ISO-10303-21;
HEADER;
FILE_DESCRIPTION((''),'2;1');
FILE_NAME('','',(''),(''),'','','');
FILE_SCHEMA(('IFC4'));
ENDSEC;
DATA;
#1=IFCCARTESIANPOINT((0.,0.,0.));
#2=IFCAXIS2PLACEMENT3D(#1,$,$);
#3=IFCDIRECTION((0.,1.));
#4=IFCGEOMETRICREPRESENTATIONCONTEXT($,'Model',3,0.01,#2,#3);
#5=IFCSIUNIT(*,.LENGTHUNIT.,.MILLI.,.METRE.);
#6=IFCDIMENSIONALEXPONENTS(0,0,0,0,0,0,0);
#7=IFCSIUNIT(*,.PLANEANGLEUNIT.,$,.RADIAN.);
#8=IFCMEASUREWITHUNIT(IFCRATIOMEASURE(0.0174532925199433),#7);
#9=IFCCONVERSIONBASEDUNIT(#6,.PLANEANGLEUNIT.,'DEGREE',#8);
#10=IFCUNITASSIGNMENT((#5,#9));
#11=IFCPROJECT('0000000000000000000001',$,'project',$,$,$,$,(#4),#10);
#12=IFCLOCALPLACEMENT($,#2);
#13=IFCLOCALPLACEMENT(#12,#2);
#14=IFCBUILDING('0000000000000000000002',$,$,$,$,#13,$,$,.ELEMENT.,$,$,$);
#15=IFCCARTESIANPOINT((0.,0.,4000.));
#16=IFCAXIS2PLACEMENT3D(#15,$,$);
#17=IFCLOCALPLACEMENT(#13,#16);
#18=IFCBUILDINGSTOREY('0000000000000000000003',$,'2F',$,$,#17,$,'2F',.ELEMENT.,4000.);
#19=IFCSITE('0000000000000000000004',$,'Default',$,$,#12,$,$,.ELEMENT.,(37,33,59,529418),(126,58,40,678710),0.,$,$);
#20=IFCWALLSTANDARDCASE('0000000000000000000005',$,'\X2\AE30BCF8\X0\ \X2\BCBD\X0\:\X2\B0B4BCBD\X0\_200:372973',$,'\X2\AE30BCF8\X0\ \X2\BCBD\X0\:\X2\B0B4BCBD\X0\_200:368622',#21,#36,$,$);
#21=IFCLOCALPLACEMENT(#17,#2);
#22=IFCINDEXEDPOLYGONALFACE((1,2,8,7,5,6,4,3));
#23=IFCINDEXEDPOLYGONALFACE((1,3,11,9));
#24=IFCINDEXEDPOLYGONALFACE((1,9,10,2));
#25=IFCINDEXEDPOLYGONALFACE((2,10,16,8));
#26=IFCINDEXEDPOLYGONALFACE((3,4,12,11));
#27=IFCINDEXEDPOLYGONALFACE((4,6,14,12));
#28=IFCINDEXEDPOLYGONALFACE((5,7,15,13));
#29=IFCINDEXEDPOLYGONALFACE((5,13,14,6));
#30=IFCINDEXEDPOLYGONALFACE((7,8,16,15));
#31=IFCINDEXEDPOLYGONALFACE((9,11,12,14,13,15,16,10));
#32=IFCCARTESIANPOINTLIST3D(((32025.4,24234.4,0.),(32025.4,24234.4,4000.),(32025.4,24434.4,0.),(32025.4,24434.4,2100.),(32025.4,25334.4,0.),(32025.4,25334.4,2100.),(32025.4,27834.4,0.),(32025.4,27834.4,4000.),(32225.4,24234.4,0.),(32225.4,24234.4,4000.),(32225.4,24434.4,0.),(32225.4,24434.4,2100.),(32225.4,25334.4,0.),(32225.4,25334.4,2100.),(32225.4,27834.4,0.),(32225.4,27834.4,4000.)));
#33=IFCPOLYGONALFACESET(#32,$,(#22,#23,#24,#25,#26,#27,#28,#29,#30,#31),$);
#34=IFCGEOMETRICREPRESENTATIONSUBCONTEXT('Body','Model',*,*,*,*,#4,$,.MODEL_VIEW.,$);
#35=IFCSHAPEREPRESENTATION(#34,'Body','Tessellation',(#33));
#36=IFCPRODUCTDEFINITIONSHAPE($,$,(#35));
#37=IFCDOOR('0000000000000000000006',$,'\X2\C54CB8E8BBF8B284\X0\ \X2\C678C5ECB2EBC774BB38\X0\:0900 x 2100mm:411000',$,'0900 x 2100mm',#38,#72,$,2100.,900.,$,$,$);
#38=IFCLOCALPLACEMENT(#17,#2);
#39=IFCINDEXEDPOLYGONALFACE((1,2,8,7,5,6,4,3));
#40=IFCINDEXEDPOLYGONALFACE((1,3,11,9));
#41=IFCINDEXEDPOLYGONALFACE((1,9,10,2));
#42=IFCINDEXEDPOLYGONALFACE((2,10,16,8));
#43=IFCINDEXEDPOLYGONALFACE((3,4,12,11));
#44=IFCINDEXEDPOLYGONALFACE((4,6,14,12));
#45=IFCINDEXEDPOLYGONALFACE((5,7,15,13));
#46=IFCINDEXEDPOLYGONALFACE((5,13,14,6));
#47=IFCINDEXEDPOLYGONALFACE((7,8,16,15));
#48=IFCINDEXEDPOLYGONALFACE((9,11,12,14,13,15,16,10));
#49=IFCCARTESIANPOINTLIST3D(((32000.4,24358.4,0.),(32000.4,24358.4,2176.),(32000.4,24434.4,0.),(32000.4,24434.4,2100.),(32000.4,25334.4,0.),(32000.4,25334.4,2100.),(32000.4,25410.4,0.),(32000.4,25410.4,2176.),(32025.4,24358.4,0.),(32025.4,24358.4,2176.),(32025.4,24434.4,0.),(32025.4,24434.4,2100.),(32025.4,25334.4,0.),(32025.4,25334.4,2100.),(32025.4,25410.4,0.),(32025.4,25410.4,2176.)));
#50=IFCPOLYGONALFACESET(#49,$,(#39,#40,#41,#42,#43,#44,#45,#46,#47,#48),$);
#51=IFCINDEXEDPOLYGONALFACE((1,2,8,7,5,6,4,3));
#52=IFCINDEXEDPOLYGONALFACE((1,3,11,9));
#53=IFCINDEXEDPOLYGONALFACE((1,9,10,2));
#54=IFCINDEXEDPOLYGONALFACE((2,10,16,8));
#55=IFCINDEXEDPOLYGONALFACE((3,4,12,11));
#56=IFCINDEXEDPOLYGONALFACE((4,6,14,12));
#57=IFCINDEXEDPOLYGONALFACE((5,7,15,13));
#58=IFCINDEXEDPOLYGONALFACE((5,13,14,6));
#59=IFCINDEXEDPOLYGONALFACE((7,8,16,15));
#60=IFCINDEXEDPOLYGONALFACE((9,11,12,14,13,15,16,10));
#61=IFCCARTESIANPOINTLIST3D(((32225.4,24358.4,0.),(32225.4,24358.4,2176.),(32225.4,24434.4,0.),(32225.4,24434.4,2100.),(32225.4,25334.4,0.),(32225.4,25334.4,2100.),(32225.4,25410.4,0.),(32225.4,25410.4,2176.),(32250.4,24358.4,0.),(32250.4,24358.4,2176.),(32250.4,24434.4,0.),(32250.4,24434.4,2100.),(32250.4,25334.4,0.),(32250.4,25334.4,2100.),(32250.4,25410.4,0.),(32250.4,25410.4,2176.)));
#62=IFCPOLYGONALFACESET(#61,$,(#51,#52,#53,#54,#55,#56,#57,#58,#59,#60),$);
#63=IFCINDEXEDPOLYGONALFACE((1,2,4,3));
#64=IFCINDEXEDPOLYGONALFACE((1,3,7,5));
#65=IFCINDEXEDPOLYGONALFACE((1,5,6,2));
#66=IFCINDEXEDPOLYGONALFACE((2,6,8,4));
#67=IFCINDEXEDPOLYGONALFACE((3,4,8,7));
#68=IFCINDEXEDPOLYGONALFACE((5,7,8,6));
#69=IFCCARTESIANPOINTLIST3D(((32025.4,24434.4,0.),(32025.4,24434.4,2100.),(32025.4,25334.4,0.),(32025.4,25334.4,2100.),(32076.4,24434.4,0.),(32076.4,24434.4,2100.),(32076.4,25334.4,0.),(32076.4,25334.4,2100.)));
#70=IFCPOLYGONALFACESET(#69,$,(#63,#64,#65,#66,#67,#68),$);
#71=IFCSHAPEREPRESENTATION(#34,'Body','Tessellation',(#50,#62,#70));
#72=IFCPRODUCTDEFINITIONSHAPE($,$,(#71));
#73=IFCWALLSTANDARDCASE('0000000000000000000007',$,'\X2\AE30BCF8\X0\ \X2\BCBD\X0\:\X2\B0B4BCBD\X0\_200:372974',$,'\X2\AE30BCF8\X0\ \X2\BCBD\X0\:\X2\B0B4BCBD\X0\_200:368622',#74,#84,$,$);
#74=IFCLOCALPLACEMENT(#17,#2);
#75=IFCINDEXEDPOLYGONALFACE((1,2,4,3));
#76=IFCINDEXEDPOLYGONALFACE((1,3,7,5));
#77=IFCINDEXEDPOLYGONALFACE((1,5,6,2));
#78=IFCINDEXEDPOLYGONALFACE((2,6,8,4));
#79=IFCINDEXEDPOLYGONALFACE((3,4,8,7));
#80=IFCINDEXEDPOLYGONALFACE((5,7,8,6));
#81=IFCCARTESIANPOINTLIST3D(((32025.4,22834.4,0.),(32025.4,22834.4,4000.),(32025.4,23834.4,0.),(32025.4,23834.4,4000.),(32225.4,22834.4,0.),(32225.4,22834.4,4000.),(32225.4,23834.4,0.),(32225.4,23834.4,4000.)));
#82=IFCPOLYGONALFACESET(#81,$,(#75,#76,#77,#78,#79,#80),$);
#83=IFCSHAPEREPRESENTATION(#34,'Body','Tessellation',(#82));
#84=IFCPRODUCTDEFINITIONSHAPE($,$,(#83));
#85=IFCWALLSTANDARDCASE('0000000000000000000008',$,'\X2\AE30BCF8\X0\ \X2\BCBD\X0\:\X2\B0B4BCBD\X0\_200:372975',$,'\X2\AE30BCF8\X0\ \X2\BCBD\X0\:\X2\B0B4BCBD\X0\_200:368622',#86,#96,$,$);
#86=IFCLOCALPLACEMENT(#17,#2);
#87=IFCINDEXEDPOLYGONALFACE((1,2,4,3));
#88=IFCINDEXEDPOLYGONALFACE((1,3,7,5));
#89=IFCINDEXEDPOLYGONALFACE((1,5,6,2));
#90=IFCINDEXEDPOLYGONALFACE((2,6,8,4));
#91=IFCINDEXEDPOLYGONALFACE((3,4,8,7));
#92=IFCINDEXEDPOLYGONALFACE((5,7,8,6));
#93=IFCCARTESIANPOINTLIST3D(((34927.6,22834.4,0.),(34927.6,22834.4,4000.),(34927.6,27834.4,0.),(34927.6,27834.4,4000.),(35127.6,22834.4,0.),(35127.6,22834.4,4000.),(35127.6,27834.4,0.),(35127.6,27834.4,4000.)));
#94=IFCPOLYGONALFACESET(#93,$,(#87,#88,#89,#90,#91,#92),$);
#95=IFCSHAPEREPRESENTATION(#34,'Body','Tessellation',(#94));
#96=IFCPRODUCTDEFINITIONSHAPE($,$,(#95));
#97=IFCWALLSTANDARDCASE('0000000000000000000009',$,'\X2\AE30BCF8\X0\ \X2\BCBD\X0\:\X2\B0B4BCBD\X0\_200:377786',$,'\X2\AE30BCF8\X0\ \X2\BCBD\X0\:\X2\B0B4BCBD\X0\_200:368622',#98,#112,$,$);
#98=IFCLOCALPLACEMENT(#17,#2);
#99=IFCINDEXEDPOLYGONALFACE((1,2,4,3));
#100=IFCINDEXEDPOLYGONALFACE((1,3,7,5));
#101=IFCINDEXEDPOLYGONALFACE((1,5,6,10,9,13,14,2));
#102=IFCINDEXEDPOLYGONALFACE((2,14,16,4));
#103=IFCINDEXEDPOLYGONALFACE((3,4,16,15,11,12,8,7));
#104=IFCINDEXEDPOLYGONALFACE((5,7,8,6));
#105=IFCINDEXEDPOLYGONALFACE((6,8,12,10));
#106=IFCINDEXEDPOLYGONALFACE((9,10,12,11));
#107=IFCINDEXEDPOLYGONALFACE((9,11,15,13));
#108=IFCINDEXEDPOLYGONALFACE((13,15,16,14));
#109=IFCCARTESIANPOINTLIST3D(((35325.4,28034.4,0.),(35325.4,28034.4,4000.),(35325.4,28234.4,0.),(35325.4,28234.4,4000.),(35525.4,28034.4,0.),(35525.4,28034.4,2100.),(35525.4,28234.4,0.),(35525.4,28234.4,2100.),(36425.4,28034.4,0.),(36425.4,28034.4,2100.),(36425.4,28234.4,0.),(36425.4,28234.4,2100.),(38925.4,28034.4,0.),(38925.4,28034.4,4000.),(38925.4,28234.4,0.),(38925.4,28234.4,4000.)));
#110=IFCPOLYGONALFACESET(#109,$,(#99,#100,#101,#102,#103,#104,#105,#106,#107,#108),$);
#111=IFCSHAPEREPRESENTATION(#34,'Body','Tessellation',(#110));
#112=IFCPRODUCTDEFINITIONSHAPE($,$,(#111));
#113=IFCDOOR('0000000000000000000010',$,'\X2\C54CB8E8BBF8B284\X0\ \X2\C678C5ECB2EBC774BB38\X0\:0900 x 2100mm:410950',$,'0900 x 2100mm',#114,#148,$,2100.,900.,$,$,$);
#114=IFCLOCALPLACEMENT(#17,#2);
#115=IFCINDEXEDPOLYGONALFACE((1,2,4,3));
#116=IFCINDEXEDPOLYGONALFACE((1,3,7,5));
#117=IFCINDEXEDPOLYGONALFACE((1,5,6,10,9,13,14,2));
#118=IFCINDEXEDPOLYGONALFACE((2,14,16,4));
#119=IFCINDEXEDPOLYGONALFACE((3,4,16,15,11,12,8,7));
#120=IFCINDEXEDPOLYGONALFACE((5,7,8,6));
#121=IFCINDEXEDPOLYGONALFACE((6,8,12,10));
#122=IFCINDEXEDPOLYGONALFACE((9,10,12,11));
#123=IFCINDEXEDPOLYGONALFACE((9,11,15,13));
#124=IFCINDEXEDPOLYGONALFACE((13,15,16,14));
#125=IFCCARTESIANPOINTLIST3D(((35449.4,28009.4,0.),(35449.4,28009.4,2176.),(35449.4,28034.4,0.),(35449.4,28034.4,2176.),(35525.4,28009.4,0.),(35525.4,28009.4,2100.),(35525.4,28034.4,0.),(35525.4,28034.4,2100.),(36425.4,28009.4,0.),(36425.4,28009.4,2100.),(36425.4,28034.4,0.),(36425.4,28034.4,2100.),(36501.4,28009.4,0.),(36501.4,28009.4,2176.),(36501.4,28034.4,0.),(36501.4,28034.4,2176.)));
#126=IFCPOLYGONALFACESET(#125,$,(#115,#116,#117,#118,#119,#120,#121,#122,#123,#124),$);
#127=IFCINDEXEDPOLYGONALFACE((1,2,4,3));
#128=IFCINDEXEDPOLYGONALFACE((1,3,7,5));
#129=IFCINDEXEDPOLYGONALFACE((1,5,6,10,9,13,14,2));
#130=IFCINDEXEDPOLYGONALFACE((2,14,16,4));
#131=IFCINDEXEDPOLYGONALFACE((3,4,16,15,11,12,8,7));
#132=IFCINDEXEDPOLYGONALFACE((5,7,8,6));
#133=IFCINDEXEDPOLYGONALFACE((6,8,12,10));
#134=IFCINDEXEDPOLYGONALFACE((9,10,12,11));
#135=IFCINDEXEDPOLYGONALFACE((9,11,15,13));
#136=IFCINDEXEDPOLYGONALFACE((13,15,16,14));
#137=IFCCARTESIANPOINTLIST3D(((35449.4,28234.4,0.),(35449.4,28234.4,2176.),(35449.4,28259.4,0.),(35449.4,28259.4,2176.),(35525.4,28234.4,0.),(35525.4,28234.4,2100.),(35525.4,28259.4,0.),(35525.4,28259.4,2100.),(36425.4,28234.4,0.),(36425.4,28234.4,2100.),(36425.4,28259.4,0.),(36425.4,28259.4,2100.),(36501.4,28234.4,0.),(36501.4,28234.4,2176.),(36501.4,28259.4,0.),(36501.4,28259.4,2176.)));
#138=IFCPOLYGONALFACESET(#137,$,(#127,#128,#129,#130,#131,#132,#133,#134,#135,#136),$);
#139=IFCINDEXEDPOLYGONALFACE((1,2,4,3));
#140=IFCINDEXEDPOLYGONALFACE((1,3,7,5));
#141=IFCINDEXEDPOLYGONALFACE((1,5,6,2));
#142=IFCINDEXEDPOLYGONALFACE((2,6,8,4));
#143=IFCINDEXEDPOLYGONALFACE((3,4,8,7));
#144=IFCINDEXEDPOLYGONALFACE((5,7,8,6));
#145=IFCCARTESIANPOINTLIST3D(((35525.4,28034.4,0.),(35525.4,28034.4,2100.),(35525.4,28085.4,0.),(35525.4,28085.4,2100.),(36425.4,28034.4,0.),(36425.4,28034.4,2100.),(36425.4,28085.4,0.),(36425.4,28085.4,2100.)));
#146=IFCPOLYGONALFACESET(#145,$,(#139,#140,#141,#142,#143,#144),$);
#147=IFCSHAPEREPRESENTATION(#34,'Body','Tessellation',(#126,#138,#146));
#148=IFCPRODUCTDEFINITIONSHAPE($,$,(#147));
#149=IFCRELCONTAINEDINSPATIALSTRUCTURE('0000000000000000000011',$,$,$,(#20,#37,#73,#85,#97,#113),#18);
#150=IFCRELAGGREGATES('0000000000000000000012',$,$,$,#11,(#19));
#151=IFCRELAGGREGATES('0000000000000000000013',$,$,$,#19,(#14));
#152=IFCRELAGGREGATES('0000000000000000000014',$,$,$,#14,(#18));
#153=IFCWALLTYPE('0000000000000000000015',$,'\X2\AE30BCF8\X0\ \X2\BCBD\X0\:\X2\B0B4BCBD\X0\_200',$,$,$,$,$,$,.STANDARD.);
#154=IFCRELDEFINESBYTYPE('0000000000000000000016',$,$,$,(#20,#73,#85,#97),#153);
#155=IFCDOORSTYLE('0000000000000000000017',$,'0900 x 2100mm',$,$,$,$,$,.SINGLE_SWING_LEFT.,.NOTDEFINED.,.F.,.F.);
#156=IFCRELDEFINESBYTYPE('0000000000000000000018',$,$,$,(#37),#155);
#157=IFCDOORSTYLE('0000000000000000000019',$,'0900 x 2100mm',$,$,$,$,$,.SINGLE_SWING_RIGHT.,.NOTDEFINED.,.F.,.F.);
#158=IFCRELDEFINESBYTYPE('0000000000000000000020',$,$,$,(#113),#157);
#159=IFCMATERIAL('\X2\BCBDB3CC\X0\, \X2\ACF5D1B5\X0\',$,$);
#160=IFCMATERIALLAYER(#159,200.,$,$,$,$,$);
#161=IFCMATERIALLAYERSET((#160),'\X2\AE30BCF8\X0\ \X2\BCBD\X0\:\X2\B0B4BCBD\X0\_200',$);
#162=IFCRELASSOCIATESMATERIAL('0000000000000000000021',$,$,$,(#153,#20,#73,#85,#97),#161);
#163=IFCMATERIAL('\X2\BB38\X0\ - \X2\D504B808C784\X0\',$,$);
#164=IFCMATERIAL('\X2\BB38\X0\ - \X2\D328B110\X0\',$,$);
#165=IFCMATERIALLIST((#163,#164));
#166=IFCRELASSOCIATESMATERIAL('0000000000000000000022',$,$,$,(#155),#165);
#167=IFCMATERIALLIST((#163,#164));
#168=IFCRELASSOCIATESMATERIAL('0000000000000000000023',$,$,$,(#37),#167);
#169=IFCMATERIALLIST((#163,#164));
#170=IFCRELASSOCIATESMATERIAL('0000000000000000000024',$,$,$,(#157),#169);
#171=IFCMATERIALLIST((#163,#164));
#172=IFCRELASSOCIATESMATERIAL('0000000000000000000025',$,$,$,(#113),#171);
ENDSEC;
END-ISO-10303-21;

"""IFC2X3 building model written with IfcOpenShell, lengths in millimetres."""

from ifc_helpers import new_model, entity, si_unit, converted_unit, direction, frame, frame_2d, origin, place, context, subcontext, project, spatial, polyline, rectangle, outline, extrude, source, transform, mapped, material, material_list, layer, layer_set, layer_usage, type_object, type_shapes, element, fill, save


model = new_model("IFC2X3")

# Units and contexts
model_context = context("Model", 3, precision=0.01, world=origin(), true_north=direction((0.0, 1.0)))
body_context = subcontext(model_context, "Body", "Model", "MODEL_VIEW")
ifc_project = project(units=[si_unit("LENGTHUNIT", "METRE", prefix="MILLI"), converted_unit("PLANEANGLEUNIT", "DEGREE", entity("IfcRatioMeasure", 0.0174532925199433), si_unit("PLANEANGLEUNIT", "RADIAN"), dimensions=[0, 0, 0, 0, 0, 0, 0])], contexts=[model_context])

# Site, building, storey
site_placement = place(None, origin())
site = spatial("IfcSite", under=ifc_project, at=site_placement, Name="Default", CompositionType="ELEMENT", RefLatitude=(37, 33, 59, 529418), RefLongitude=(126, 58, 40, 678710), RefElevation=0.0)
building_placement = place(site_placement, origin())
building = spatial("IfcBuilding", under=site, at=building_placement, CompositionType="ELEMENT")
storey_placement = place(building_placement, frame((0.0, 0.0, 4000.0)))
storey = spatial("IfcBuildingStorey", under=building, at=storey_placement, Name="2F", LongName="2F", CompositionType="ELEMENT", Elevation=4000.0)

# Wall, opening, door
ifc_material_1 = material(Name="벽돌, 공통")
ifc_layer_1 = layer(ifc_material_1, 200.0)
ifc_layer_set_1 = layer_set([ifc_layer_1], Name="기본 벽:내벽_200")
ifc_layer_usage_1 = layer_usage(ifc_layer_set_1, "AXIS2", "NEGATIVE", 100.0)
wall_type_1 = type_object("IfcWallType", Name="기본 벽:내벽_200", PredefinedType="STANDARD", material=ifc_layer_set_1)
wall_1_placement = place(storey_placement, frame((32125.4, 24234.4, 0.0), z_axis=(0.0, 0.0, 1.0), x_axis=(0.0, 1.0, 0.0)))
wall_1 = element("IfcWallStandardCase", 1, at=wall_1_placement, inside=storey, type_object=wall_type_1, material=ifc_layer_usage_1, Name="기본 벽:내벽_200:372973", ObjectType="기본 벽:내벽_200:368622", context=body_context, shape_type="SweptSolid", body=[
    extrude(rectangle(XDim=3600.0, YDim=200.0, at=frame_2d((1800.0, 0.0), x_axis=(-1.0, 0.0))), origin(), (0.0, 0.0, 1.0), 4000.0),
])
opening_1_placement = place(wall_1_placement, frame((200.0, -100.0, 0.0)))
opening_1 = element("IfcOpeningElement", 2, at=opening_1_placement, cuts=wall_1, ObjectType="Opening", context=body_context, shape_type="SweptSolid", body=[
    extrude(rectangle(XDim=900.0, YDim=2100.0, at=frame_2d((1050.0, 450.0), x_axis=(0.0, -1.0))), frame((0.0, 0.0, 0.0), z_axis=(0.0, 1.0, 0.0), x_axis=(0.0, 0.0, 1.0)), (0.0, 0.0, 1.0), 200.0),
])
ifc_material_2 = material(Name="문 - 프레임")
ifc_material_3 = material(Name="문 - 패널")
ifc_material_list_1 = material_list([ifc_material_2, ifc_material_3])
ifc_material_list_2 = material_list([ifc_material_2, ifc_material_3])
door_style_1 = type_object("IfcDoorStyle", Name="0900 x 2100mm", ConstructionType="NOTDEFINED", OperationType="SINGLE_SWING_LEFT", ParameterTakesPrecedence=False, Sizeable=False, material=ifc_material_list_2)
shared_shape_1 = source(origin(), body_context, "Body", "SweptSolid", [
    extrude(outline(polyline([(-526.0, -1107.0), (526.0, -1107.0), (526.0, 1069.0), (450.0, 1069.0), (450.0, -1031.0), (-450.0, -1031.0), (-450.0, 1069.0), (-526.0, 1069.0), (-526.0, -1107.0)])), frame((450.0, 225.0, 1069.0), z_axis=(0.0, -1.0, 0.0), x_axis=(-1.0, 0.0, 0.0)), (0.0, 0.0, 1.0), 25.0),
    extrude(outline(polyline([(-1107.0, -526.0), (1069.0, -526.0), (1069.0, -450.0), (-1031.0, -450.0), (-1031.0, 450.0), (1069.0, 450.0), (1069.0, 526.0), (-1107.0, 526.0), (-1107.0, -526.0)])), frame((450.0, 0.0, 1069.0), z_axis=(0.0, -1.0, 0.0), x_axis=(0.0, 0.0, -1.0)), (0.0, 0.0, 1.0), 25.0),
    extrude(rectangle(XDim=900.0, YDim=51.0, at=frame_2d((0.0, 0.0), x_axis=(1.0, 0.0))), frame((450.0, 174.5, 0.0)), (0.0, 0.0, 1.0), 2100.0),
])
type_shapes(door_style_1, [shared_shape_1])
door_1_placement = place(opening_1_placement, frame((0.0, 0.0, 0.0)))
door_1 = element("IfcDoor", 3, at=door_1_placement, inside=storey, type_object=door_style_1, material=ifc_material_list_1, Name="알루미늄 외여닫이문:0900 x 2100mm:411000", ObjectType="0900 x 2100mm", OverallHeight=2100.0, OverallWidth=900.0, context=body_context, shape_type="MappedRepresentation", body=[
    mapped(shared_shape_1, transform((0.0, 0.0, 0.0), scale=1.0)),
])
fill(opening_1, door_1)

# Walls
ifc_layer_usage_2 = layer_usage(ifc_layer_set_1, "AXIS2", "NEGATIVE", 100.0)
wall_2_placement = place(storey_placement, frame((32125.4, 22834.4, 0.0), z_axis=(0.0, 0.0, 1.0), x_axis=(0.0, 1.0, 0.0)))
element("IfcWallStandardCase", 4, at=wall_2_placement, inside=storey, type_object=wall_type_1, material=ifc_layer_usage_2, Name="기본 벽:내벽_200:372974", ObjectType="기본 벽:내벽_200:368622", context=body_context, shape_type="SweptSolid", body=[
    extrude(rectangle(XDim=1000.0, YDim=200.0, at=frame_2d((500.0, 0.0), x_axis=(-1.0, 0.0))), origin(), (0.0, 0.0, 1.0), 4000.0),
])
ifc_layer_usage_3 = layer_usage(ifc_layer_set_1, "AXIS2", "NEGATIVE", 100.0)
wall_3_placement = place(storey_placement, frame((35027.6, 22834.4, 0.0), z_axis=(0.0, 0.0, 1.0), x_axis=(0.0, 1.0, 0.0)))
element("IfcWallStandardCase", 5, at=wall_3_placement, inside=storey, type_object=wall_type_1, material=ifc_layer_usage_3, Name="기본 벽:내벽_200:372975", ObjectType="기본 벽:내벽_200:368622", context=body_context, shape_type="SweptSolid", body=[
    extrude(rectangle(XDim=5000.0, YDim=200.0, at=frame_2d((2500.0, 0.0), x_axis=(-1.0, 0.0))), origin(), (0.0, 0.0, 1.0), 4000.0),
])

# Wall, opening, door
ifc_layer_usage_4 = layer_usage(ifc_layer_set_1, "AXIS2", "NEGATIVE", 100.0)
wall_4_placement = place(storey_placement, frame((35325.4, 28134.4, 0.0)))
wall_4 = element("IfcWallStandardCase", 6, at=wall_4_placement, inside=storey, type_object=wall_type_1, material=ifc_layer_usage_4, Name="기본 벽:내벽_200:377786", ObjectType="기본 벽:내벽_200:368622", context=body_context, shape_type="SweptSolid", body=[
    extrude(rectangle(XDim=3600.0, YDim=200.0, at=frame_2d((1800.0, 0.0), x_axis=(-1.0, 0.0))), origin(), (0.0, 0.0, 1.0), 4000.0),
])
opening_2_placement = place(wall_4_placement, frame((1100.0, 100.0, 0.0)))
opening_2 = element("IfcOpeningElement", 7, at=opening_2_placement, cuts=wall_4, ObjectType="Opening", context=body_context, shape_type="SweptSolid", body=[
    extrude(rectangle(XDim=900.0, YDim=2100.0, at=frame_2d((1050.0, 450.0), x_axis=(0.0, 1.0))), frame((0.0, 0.0, 0.0), z_axis=(0.0, -1.0, 0.0), x_axis=(0.0, 0.0, 1.0)), (0.0, 0.0, 1.0), 200.0),
])
ifc_material_list_3 = material_list([ifc_material_2, ifc_material_3])
ifc_material_list_4 = material_list([ifc_material_2, ifc_material_3])
door_style_2 = type_object("IfcDoorStyle", Name="0900 x 2100mm", ConstructionType="NOTDEFINED", OperationType="SINGLE_SWING_RIGHT", ParameterTakesPrecedence=False, Sizeable=False, material=ifc_material_list_4)
shared_shape_2 = source(origin(), body_context, "Body", "SweptSolid", [
    extrude(outline(polyline([(-526.0, -1107.0), (526.0, -1107.0), (526.0, 1069.0), (450.0, 1069.0), (450.0, -1031.0), (-450.0, -1031.0), (-450.0, 1069.0), (-526.0, 1069.0), (-526.0, -1107.0)])), frame((450.0, 200.0, 1069.0), z_axis=(0.0, 1.0, 0.0), x_axis=(1.0, 0.0, 0.0)), (0.0, 0.0, 1.0), 25.0),
    extrude(outline(polyline([(-1107.0, -526.0), (1069.0, -526.0), (1069.0, -450.0), (-1031.0, -450.0), (-1031.0, 450.0), (1069.0, 450.0), (1069.0, 526.0), (-1107.0, 526.0), (-1107.0, -526.0)])), frame((450.0, -25.0, 1069.0), z_axis=(0.0, 1.0, 0.0), x_axis=(0.0, 0.0, -1.0)), (0.0, 0.0, 1.0), 25.0),
    extrude(rectangle(XDim=51.0, YDim=900.0, at=frame_2d((0.0, 0.0), x_axis=(1.0, 0.0))), frame((450.0, 174.5, 0.0), z_axis=(0.0, 0.0, 1.0), x_axis=(0.0, 1.0, 0.0)), (0.0, 0.0, 1.0), 2100.0),
])
type_shapes(door_style_2, [shared_shape_2])
door_2_placement = place(opening_2_placement, frame((0.0, 0.0, 0.0), z_axis=(0.0, 0.0, 1.0), x_axis=(-1.0, 0.0, 0.0)))
door_2 = element("IfcDoor", 8, at=door_2_placement, inside=storey, type_object=door_style_2, material=ifc_material_list_3, Name="알루미늄 외여닫이문:0900 x 2100mm:410950", ObjectType="0900 x 2100mm", OverallHeight=2100.0, OverallWidth=900.0, context=body_context, shape_type="MappedRepresentation", body=[
    mapped(shared_shape_2, transform((0.0, 0.0, 0.0), scale=1.0)),
])
fill(opening_2, door_2)

save(model, "model.ifc")
